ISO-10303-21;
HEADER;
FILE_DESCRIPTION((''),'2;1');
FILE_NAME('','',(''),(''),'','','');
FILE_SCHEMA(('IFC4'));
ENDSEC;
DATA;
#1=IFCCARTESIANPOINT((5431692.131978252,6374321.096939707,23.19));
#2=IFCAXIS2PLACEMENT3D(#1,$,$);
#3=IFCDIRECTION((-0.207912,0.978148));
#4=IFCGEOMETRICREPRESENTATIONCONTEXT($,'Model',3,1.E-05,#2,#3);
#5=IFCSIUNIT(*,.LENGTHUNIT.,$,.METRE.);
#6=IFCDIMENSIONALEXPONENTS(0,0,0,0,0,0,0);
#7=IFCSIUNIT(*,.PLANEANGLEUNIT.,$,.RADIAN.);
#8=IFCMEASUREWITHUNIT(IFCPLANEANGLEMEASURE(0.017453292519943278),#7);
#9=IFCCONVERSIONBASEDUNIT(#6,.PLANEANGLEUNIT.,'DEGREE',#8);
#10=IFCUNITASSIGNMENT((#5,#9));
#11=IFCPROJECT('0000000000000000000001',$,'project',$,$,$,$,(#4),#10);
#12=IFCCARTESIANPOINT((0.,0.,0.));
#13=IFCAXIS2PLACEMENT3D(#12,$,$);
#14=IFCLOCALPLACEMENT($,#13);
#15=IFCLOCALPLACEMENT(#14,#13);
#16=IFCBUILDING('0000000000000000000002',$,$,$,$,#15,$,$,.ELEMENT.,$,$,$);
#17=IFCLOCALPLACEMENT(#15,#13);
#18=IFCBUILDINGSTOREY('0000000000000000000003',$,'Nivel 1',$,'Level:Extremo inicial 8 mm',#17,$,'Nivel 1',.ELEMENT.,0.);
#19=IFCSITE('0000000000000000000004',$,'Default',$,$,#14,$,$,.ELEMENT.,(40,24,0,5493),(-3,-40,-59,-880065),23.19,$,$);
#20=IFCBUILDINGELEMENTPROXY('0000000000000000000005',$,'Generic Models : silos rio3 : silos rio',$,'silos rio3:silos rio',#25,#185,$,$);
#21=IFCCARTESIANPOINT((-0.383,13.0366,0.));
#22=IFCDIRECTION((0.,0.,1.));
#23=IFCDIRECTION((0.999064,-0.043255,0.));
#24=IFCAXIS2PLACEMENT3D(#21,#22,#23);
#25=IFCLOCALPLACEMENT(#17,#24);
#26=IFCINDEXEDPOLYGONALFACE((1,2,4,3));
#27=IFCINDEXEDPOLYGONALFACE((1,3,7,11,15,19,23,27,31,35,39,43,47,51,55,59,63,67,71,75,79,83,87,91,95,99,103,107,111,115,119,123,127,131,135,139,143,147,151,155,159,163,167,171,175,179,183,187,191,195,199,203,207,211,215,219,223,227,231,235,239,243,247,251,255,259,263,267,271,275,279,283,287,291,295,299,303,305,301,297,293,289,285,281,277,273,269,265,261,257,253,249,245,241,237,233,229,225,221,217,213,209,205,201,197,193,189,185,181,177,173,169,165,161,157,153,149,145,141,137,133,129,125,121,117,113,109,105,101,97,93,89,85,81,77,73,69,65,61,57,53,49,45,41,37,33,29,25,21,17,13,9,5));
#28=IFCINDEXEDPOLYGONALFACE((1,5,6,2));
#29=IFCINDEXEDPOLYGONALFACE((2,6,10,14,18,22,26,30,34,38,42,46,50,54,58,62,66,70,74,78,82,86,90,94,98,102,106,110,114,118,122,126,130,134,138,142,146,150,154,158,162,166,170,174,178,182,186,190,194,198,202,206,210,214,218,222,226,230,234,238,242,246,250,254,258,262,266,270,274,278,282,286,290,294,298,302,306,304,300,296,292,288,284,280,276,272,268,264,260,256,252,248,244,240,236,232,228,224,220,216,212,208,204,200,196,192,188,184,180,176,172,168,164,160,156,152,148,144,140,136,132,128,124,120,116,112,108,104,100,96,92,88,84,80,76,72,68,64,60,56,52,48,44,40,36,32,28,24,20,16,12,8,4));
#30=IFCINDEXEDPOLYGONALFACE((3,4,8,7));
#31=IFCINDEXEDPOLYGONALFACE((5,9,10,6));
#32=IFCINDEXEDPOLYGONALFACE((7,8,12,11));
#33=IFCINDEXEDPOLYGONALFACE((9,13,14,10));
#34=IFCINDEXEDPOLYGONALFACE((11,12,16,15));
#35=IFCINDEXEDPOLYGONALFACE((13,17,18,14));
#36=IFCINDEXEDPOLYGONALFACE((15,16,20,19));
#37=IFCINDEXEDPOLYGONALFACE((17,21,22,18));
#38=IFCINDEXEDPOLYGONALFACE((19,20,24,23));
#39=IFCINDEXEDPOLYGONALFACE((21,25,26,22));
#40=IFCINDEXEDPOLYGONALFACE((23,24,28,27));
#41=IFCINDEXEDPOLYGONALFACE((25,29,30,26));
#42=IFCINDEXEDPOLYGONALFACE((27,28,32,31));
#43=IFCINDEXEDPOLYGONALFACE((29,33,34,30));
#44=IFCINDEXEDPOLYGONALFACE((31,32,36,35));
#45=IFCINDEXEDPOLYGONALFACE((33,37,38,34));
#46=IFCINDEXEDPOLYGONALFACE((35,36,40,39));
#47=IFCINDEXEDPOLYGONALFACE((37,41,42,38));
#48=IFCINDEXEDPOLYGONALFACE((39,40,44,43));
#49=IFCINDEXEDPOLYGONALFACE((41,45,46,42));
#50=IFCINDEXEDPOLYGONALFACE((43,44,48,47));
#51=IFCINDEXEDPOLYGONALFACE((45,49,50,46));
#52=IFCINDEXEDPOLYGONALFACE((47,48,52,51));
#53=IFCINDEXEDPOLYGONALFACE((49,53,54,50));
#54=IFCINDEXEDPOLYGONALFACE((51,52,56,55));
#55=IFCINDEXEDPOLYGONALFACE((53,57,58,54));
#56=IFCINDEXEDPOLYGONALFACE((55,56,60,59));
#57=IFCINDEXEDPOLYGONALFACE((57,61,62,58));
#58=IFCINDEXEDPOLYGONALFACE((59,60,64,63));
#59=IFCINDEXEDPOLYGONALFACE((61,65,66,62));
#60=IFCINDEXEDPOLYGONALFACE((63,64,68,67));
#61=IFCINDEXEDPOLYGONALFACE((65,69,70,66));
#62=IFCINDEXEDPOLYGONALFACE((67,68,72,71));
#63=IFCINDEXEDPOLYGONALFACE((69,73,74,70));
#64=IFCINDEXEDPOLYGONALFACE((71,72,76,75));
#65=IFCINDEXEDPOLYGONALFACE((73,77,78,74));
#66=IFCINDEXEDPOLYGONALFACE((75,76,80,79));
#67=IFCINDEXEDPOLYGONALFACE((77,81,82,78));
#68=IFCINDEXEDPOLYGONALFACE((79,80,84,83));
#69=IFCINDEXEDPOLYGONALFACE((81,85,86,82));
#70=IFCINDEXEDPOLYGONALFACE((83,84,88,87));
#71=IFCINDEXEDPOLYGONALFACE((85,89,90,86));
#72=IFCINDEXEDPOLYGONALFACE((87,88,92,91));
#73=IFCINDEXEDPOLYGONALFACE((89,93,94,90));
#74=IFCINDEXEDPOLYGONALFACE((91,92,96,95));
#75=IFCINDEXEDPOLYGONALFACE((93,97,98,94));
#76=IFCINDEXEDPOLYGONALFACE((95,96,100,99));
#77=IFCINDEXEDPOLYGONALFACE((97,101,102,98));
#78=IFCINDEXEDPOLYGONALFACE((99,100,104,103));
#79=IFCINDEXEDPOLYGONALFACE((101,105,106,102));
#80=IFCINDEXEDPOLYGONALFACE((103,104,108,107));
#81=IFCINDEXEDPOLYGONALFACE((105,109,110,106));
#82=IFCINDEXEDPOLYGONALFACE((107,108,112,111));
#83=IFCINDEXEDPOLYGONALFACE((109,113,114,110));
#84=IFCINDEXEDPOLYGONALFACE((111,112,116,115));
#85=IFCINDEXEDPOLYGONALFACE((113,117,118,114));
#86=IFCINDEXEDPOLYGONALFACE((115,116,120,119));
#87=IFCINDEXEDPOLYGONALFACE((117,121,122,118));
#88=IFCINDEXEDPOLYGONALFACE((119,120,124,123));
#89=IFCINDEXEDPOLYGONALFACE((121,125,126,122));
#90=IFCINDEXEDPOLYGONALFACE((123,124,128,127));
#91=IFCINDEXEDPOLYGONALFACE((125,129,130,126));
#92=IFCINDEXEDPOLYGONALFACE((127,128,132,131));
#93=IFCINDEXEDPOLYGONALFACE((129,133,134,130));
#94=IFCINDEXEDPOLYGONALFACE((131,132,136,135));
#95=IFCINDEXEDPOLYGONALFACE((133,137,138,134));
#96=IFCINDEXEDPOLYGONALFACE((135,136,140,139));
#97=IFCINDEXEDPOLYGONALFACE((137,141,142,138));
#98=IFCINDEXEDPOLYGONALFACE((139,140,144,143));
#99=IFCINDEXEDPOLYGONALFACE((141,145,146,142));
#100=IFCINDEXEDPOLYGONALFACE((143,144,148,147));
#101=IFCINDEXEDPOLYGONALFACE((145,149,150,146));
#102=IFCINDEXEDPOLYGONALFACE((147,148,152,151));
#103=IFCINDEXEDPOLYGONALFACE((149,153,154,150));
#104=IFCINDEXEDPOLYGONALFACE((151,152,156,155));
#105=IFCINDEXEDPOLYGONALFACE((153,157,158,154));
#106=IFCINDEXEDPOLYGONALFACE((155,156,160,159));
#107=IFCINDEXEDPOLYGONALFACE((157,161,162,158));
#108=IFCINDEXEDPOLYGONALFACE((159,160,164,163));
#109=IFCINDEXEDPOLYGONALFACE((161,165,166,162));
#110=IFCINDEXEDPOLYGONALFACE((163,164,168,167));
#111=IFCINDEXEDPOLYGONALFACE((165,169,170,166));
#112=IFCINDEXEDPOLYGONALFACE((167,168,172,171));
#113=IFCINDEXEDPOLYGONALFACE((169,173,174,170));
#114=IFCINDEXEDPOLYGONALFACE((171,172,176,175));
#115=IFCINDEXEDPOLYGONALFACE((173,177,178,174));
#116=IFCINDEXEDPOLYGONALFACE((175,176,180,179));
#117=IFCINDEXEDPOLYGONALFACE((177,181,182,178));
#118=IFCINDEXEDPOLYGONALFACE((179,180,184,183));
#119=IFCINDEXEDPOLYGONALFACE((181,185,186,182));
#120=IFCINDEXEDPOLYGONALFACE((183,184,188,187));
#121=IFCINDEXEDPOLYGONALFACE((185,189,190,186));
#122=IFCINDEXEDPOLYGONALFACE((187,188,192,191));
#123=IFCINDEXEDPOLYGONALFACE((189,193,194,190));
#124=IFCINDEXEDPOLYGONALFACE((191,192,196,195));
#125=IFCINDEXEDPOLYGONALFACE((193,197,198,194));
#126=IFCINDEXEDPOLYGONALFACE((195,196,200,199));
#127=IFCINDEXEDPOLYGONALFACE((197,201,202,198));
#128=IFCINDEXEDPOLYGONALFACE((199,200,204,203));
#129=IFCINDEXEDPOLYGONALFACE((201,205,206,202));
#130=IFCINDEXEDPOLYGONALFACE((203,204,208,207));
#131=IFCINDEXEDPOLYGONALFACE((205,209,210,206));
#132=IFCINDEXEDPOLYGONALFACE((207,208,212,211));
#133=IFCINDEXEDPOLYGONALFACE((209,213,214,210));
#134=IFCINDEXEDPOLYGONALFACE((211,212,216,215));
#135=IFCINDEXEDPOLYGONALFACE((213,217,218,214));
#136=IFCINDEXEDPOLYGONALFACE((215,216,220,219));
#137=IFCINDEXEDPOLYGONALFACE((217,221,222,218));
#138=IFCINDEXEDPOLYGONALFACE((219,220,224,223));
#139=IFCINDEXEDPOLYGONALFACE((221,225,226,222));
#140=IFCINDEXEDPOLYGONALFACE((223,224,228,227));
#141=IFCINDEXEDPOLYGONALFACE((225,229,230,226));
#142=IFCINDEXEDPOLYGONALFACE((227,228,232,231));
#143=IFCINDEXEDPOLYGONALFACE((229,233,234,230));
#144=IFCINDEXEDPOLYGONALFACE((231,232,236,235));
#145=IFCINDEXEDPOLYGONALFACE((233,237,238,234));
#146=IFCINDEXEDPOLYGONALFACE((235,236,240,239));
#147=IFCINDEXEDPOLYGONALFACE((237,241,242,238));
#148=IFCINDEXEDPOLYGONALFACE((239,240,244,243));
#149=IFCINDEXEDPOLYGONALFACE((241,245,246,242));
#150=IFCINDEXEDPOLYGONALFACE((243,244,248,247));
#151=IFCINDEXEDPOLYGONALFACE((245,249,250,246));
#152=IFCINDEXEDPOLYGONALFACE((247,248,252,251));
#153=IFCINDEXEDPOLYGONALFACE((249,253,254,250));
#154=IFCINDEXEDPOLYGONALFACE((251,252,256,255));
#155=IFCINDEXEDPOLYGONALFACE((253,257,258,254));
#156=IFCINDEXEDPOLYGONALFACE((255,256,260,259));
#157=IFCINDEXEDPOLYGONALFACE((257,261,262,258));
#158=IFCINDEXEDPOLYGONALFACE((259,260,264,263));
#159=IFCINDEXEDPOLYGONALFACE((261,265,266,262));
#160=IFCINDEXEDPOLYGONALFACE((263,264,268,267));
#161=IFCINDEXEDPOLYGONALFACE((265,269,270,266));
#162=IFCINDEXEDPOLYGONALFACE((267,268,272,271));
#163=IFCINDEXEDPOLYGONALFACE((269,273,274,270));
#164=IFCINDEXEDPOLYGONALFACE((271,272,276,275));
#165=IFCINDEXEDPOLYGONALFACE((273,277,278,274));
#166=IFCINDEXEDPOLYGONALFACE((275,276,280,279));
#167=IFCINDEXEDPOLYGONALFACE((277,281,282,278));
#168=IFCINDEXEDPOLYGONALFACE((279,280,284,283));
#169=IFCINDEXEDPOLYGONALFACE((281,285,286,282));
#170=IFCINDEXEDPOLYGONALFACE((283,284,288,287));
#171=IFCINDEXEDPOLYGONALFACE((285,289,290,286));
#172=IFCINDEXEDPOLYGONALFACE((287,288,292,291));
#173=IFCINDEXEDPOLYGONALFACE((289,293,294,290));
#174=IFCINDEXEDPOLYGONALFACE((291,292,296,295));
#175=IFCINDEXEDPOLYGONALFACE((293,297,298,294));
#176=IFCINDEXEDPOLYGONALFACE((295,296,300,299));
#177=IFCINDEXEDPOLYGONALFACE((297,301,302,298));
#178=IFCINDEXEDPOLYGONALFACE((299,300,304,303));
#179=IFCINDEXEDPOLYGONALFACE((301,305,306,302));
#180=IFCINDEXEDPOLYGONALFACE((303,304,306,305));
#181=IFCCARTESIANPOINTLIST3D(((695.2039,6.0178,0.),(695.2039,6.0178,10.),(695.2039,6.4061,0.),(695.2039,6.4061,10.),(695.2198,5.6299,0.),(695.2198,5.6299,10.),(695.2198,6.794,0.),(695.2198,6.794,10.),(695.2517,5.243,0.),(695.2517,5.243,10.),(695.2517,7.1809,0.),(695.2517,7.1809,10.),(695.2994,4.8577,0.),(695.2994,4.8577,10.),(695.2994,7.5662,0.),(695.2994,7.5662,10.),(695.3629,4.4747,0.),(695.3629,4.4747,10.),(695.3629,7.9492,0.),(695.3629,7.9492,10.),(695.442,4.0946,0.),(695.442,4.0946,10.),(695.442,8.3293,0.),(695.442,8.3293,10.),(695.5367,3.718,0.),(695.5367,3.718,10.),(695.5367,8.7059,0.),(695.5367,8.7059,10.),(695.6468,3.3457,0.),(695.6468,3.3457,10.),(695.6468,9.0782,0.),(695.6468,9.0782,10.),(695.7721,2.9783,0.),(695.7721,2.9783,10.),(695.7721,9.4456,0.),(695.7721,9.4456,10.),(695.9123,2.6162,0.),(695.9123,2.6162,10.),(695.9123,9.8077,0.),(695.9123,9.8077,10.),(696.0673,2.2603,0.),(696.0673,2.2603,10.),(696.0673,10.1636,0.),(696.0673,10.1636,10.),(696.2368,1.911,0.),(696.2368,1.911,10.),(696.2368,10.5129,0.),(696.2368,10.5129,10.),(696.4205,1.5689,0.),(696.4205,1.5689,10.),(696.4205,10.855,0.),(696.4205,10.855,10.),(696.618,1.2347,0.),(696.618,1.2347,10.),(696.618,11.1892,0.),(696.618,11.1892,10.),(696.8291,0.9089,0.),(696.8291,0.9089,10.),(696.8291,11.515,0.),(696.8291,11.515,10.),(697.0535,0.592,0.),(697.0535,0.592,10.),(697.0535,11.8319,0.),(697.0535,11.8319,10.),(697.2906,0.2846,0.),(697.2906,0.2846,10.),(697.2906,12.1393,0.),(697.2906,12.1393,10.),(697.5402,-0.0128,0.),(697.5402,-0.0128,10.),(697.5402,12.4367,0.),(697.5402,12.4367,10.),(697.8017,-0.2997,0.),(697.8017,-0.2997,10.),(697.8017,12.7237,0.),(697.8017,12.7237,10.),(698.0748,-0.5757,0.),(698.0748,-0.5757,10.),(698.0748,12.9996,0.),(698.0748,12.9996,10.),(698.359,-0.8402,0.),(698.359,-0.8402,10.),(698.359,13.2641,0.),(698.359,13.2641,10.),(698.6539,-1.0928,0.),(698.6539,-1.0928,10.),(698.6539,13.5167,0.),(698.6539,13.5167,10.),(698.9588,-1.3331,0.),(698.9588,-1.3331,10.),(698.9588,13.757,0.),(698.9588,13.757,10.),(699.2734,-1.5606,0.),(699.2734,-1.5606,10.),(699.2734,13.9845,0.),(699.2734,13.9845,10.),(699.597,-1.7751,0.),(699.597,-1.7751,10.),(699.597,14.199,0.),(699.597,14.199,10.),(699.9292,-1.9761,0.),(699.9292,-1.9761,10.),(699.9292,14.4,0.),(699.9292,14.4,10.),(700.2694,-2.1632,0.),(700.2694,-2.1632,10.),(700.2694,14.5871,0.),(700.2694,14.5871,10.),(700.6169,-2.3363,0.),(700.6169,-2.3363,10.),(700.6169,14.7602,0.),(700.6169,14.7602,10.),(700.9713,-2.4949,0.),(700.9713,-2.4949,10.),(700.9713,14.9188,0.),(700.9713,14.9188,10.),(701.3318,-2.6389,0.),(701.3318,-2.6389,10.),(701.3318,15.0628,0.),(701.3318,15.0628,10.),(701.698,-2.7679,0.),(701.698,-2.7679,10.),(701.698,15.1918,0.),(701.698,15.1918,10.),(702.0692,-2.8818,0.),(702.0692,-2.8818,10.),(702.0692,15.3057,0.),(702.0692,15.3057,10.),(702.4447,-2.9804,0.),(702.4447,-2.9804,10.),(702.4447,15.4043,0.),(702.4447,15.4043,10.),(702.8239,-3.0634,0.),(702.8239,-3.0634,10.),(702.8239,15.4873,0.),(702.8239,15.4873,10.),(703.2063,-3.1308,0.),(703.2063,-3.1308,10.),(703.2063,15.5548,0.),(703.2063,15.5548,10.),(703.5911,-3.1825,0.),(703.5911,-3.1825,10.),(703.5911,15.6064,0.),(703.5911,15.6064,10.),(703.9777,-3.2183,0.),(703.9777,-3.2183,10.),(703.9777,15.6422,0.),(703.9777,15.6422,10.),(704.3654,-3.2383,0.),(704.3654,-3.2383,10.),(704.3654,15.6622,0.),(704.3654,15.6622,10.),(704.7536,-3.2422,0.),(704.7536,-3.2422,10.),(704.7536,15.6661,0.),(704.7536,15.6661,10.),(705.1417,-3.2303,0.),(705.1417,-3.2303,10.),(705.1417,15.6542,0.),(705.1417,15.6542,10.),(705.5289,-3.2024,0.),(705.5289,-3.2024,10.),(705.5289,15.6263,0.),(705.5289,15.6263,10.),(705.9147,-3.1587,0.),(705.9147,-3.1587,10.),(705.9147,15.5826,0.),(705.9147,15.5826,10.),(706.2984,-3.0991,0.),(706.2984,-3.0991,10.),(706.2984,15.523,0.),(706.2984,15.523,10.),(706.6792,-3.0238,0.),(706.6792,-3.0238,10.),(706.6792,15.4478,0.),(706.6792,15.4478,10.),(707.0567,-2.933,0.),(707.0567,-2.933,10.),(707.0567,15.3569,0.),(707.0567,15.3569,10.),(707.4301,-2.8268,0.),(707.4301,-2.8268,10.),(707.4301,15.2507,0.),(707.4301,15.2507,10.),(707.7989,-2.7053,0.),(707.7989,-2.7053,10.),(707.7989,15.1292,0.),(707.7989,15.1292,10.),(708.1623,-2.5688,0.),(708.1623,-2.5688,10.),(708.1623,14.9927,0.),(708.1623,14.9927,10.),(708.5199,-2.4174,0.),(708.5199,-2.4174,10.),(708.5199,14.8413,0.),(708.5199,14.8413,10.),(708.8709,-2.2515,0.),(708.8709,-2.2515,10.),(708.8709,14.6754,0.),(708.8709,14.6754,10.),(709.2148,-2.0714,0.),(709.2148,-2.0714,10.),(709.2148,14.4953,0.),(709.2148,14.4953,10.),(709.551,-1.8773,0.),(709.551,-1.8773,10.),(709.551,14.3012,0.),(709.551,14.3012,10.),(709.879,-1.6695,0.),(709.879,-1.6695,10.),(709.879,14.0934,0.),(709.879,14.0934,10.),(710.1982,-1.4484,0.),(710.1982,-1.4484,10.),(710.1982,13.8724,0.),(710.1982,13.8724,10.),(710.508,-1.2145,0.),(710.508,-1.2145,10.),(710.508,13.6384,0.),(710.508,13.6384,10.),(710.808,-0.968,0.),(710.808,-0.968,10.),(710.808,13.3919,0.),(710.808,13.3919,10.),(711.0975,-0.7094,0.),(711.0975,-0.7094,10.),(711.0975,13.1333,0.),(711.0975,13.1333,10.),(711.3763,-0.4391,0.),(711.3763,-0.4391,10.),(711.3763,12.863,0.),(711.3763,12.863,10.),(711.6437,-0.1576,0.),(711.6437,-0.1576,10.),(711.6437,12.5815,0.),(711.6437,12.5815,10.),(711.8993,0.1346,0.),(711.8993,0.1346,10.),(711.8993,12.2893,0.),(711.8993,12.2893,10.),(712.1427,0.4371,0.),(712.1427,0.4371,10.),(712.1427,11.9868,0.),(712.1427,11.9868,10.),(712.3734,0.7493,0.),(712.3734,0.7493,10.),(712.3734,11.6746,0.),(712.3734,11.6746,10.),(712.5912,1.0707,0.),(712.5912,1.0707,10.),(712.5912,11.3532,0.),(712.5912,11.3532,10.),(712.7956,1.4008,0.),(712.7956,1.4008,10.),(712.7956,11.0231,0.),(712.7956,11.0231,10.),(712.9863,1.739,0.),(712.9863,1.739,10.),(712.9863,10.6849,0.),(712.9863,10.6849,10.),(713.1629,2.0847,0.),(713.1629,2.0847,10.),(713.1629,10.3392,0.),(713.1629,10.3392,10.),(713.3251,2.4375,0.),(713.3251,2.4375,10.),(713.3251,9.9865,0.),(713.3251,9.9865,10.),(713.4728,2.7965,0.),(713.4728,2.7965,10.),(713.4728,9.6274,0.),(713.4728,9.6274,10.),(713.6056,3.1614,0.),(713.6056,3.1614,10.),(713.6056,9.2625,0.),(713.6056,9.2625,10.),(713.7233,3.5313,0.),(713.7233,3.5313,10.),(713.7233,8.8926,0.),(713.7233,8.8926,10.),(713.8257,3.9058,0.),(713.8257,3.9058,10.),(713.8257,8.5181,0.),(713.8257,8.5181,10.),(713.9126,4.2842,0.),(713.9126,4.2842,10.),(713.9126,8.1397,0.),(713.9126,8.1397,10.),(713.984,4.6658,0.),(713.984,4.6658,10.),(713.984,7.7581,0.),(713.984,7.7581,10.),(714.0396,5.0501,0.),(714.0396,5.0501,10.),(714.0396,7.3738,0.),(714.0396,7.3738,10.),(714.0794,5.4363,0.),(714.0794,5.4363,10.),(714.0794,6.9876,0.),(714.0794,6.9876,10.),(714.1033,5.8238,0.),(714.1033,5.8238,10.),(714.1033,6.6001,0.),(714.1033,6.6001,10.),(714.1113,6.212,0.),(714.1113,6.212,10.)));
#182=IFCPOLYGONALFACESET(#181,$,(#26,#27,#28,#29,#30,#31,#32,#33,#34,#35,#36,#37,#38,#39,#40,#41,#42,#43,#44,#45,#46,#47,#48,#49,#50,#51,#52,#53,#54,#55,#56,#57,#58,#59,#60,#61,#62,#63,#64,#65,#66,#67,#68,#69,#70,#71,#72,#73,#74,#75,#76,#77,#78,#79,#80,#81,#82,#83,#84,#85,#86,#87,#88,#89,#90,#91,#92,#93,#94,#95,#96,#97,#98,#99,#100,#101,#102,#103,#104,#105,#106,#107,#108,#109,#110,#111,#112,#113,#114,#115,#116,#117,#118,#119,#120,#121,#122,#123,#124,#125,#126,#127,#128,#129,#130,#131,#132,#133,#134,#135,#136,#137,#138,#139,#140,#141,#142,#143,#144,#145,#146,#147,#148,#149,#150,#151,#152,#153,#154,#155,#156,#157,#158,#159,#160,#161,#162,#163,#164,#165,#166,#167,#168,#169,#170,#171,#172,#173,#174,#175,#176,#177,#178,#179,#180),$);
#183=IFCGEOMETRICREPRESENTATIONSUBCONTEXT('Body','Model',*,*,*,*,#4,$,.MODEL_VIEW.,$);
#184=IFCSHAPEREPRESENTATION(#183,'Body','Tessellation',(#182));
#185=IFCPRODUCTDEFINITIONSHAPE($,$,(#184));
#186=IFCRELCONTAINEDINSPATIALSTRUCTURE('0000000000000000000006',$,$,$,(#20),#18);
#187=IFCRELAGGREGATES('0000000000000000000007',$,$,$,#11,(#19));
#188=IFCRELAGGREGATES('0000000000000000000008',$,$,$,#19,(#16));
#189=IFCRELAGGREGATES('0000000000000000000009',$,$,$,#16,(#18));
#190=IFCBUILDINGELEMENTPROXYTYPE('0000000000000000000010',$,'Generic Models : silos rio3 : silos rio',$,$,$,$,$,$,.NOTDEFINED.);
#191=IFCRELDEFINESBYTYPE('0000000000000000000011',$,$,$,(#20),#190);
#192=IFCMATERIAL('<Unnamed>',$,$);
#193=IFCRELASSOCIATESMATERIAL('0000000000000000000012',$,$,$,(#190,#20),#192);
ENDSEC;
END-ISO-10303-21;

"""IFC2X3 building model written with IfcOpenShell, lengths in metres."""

from ifc_helpers import new_model, entity, si_unit, converted_unit, direction, frame, frame_2d, origin, place, context, subcontext, project, spatial, circle, extrude, source, transform, mapped, material, type_object, type_shapes, element, save


model = new_model("IFC2X3")

# Units and contexts
model_context = context("Model", 3, precision=1e-05, world=frame((5431692.131978252, 6374321.096939707, 23.19)), true_north=direction((-0.207912, 0.978148)))
body_context = subcontext(model_context, "Body", "Model", "MODEL_VIEW")
ifc_project = project(units=[si_unit("LENGTHUNIT", "METRE"), converted_unit("PLANEANGLEUNIT", "DEGREE", entity("IfcPlaneAngleMeasure", 0.017453292519943278), si_unit("PLANEANGLEUNIT", "RADIAN"), dimensions=[0, 0, 0, 0, 0, 0, 0])], contexts=[model_context])

# Site, building, storey
site_placement = place(None, origin())
site = spatial("IfcSite", under=ifc_project, at=site_placement, Name="Default", CompositionType="ELEMENT", RefLatitude=(40, 24, 0, 5493), RefLongitude=(-3, -40, -59, -880065), RefElevation=23.19)
building_placement = place(site_placement, origin())
building = spatial("IfcBuilding", under=site, at=building_placement, CompositionType="ELEMENT")
storey_placement = place(building_placement, origin())
storey = spatial("IfcBuildingStorey", under=building, at=storey_placement, Name="Nivel 1", ObjectType="Level:Extremo inicial 8 mm", LongName="Nivel 1", CompositionType="ELEMENT", Elevation=0.0)

# Building element proxy
ifc_material_1 = material(Name="<Unnamed>")
building_element_proxy_type_1 = type_object("IfcBuildingElementProxyType", Name="Generic Models : silos rio3 : silos rio", PredefinedType="NOTDEFINED", material=ifc_material_1)
shared_shape_1 = source(origin(), body_context, "Body", "SweptSolid", [
    extrude(circle(Radius=9.4547, at=frame_2d((0.0, 0.0), x_axis=(1.0, 0.0))), frame((704.6566, 6.212, 0.0)), (0.0, 0.0, 1.0), 10.0),
])
type_shapes(building_element_proxy_type_1, [shared_shape_1])
proxy_1_placement = place(storey_placement, frame((-0.383, 13.0366, 0.0), z_axis=(0.0, 0.0, 1.0), x_axis=(0.999064, -0.043255, 0.0)))
element("IfcBuildingElementProxy", 1, at=proxy_1_placement, inside=storey, type_object=building_element_proxy_type_1, material=ifc_material_1, Name="Generic Models : silos rio3 : silos rio", ObjectType="silos rio3:silos rio", context=body_context, shape_type="MappedRepresentation", body=[
    mapped(shared_shape_1, transform((0.0, 0.0, 0.0), scale=1.0)),
])

save(model, "model.ifc")
